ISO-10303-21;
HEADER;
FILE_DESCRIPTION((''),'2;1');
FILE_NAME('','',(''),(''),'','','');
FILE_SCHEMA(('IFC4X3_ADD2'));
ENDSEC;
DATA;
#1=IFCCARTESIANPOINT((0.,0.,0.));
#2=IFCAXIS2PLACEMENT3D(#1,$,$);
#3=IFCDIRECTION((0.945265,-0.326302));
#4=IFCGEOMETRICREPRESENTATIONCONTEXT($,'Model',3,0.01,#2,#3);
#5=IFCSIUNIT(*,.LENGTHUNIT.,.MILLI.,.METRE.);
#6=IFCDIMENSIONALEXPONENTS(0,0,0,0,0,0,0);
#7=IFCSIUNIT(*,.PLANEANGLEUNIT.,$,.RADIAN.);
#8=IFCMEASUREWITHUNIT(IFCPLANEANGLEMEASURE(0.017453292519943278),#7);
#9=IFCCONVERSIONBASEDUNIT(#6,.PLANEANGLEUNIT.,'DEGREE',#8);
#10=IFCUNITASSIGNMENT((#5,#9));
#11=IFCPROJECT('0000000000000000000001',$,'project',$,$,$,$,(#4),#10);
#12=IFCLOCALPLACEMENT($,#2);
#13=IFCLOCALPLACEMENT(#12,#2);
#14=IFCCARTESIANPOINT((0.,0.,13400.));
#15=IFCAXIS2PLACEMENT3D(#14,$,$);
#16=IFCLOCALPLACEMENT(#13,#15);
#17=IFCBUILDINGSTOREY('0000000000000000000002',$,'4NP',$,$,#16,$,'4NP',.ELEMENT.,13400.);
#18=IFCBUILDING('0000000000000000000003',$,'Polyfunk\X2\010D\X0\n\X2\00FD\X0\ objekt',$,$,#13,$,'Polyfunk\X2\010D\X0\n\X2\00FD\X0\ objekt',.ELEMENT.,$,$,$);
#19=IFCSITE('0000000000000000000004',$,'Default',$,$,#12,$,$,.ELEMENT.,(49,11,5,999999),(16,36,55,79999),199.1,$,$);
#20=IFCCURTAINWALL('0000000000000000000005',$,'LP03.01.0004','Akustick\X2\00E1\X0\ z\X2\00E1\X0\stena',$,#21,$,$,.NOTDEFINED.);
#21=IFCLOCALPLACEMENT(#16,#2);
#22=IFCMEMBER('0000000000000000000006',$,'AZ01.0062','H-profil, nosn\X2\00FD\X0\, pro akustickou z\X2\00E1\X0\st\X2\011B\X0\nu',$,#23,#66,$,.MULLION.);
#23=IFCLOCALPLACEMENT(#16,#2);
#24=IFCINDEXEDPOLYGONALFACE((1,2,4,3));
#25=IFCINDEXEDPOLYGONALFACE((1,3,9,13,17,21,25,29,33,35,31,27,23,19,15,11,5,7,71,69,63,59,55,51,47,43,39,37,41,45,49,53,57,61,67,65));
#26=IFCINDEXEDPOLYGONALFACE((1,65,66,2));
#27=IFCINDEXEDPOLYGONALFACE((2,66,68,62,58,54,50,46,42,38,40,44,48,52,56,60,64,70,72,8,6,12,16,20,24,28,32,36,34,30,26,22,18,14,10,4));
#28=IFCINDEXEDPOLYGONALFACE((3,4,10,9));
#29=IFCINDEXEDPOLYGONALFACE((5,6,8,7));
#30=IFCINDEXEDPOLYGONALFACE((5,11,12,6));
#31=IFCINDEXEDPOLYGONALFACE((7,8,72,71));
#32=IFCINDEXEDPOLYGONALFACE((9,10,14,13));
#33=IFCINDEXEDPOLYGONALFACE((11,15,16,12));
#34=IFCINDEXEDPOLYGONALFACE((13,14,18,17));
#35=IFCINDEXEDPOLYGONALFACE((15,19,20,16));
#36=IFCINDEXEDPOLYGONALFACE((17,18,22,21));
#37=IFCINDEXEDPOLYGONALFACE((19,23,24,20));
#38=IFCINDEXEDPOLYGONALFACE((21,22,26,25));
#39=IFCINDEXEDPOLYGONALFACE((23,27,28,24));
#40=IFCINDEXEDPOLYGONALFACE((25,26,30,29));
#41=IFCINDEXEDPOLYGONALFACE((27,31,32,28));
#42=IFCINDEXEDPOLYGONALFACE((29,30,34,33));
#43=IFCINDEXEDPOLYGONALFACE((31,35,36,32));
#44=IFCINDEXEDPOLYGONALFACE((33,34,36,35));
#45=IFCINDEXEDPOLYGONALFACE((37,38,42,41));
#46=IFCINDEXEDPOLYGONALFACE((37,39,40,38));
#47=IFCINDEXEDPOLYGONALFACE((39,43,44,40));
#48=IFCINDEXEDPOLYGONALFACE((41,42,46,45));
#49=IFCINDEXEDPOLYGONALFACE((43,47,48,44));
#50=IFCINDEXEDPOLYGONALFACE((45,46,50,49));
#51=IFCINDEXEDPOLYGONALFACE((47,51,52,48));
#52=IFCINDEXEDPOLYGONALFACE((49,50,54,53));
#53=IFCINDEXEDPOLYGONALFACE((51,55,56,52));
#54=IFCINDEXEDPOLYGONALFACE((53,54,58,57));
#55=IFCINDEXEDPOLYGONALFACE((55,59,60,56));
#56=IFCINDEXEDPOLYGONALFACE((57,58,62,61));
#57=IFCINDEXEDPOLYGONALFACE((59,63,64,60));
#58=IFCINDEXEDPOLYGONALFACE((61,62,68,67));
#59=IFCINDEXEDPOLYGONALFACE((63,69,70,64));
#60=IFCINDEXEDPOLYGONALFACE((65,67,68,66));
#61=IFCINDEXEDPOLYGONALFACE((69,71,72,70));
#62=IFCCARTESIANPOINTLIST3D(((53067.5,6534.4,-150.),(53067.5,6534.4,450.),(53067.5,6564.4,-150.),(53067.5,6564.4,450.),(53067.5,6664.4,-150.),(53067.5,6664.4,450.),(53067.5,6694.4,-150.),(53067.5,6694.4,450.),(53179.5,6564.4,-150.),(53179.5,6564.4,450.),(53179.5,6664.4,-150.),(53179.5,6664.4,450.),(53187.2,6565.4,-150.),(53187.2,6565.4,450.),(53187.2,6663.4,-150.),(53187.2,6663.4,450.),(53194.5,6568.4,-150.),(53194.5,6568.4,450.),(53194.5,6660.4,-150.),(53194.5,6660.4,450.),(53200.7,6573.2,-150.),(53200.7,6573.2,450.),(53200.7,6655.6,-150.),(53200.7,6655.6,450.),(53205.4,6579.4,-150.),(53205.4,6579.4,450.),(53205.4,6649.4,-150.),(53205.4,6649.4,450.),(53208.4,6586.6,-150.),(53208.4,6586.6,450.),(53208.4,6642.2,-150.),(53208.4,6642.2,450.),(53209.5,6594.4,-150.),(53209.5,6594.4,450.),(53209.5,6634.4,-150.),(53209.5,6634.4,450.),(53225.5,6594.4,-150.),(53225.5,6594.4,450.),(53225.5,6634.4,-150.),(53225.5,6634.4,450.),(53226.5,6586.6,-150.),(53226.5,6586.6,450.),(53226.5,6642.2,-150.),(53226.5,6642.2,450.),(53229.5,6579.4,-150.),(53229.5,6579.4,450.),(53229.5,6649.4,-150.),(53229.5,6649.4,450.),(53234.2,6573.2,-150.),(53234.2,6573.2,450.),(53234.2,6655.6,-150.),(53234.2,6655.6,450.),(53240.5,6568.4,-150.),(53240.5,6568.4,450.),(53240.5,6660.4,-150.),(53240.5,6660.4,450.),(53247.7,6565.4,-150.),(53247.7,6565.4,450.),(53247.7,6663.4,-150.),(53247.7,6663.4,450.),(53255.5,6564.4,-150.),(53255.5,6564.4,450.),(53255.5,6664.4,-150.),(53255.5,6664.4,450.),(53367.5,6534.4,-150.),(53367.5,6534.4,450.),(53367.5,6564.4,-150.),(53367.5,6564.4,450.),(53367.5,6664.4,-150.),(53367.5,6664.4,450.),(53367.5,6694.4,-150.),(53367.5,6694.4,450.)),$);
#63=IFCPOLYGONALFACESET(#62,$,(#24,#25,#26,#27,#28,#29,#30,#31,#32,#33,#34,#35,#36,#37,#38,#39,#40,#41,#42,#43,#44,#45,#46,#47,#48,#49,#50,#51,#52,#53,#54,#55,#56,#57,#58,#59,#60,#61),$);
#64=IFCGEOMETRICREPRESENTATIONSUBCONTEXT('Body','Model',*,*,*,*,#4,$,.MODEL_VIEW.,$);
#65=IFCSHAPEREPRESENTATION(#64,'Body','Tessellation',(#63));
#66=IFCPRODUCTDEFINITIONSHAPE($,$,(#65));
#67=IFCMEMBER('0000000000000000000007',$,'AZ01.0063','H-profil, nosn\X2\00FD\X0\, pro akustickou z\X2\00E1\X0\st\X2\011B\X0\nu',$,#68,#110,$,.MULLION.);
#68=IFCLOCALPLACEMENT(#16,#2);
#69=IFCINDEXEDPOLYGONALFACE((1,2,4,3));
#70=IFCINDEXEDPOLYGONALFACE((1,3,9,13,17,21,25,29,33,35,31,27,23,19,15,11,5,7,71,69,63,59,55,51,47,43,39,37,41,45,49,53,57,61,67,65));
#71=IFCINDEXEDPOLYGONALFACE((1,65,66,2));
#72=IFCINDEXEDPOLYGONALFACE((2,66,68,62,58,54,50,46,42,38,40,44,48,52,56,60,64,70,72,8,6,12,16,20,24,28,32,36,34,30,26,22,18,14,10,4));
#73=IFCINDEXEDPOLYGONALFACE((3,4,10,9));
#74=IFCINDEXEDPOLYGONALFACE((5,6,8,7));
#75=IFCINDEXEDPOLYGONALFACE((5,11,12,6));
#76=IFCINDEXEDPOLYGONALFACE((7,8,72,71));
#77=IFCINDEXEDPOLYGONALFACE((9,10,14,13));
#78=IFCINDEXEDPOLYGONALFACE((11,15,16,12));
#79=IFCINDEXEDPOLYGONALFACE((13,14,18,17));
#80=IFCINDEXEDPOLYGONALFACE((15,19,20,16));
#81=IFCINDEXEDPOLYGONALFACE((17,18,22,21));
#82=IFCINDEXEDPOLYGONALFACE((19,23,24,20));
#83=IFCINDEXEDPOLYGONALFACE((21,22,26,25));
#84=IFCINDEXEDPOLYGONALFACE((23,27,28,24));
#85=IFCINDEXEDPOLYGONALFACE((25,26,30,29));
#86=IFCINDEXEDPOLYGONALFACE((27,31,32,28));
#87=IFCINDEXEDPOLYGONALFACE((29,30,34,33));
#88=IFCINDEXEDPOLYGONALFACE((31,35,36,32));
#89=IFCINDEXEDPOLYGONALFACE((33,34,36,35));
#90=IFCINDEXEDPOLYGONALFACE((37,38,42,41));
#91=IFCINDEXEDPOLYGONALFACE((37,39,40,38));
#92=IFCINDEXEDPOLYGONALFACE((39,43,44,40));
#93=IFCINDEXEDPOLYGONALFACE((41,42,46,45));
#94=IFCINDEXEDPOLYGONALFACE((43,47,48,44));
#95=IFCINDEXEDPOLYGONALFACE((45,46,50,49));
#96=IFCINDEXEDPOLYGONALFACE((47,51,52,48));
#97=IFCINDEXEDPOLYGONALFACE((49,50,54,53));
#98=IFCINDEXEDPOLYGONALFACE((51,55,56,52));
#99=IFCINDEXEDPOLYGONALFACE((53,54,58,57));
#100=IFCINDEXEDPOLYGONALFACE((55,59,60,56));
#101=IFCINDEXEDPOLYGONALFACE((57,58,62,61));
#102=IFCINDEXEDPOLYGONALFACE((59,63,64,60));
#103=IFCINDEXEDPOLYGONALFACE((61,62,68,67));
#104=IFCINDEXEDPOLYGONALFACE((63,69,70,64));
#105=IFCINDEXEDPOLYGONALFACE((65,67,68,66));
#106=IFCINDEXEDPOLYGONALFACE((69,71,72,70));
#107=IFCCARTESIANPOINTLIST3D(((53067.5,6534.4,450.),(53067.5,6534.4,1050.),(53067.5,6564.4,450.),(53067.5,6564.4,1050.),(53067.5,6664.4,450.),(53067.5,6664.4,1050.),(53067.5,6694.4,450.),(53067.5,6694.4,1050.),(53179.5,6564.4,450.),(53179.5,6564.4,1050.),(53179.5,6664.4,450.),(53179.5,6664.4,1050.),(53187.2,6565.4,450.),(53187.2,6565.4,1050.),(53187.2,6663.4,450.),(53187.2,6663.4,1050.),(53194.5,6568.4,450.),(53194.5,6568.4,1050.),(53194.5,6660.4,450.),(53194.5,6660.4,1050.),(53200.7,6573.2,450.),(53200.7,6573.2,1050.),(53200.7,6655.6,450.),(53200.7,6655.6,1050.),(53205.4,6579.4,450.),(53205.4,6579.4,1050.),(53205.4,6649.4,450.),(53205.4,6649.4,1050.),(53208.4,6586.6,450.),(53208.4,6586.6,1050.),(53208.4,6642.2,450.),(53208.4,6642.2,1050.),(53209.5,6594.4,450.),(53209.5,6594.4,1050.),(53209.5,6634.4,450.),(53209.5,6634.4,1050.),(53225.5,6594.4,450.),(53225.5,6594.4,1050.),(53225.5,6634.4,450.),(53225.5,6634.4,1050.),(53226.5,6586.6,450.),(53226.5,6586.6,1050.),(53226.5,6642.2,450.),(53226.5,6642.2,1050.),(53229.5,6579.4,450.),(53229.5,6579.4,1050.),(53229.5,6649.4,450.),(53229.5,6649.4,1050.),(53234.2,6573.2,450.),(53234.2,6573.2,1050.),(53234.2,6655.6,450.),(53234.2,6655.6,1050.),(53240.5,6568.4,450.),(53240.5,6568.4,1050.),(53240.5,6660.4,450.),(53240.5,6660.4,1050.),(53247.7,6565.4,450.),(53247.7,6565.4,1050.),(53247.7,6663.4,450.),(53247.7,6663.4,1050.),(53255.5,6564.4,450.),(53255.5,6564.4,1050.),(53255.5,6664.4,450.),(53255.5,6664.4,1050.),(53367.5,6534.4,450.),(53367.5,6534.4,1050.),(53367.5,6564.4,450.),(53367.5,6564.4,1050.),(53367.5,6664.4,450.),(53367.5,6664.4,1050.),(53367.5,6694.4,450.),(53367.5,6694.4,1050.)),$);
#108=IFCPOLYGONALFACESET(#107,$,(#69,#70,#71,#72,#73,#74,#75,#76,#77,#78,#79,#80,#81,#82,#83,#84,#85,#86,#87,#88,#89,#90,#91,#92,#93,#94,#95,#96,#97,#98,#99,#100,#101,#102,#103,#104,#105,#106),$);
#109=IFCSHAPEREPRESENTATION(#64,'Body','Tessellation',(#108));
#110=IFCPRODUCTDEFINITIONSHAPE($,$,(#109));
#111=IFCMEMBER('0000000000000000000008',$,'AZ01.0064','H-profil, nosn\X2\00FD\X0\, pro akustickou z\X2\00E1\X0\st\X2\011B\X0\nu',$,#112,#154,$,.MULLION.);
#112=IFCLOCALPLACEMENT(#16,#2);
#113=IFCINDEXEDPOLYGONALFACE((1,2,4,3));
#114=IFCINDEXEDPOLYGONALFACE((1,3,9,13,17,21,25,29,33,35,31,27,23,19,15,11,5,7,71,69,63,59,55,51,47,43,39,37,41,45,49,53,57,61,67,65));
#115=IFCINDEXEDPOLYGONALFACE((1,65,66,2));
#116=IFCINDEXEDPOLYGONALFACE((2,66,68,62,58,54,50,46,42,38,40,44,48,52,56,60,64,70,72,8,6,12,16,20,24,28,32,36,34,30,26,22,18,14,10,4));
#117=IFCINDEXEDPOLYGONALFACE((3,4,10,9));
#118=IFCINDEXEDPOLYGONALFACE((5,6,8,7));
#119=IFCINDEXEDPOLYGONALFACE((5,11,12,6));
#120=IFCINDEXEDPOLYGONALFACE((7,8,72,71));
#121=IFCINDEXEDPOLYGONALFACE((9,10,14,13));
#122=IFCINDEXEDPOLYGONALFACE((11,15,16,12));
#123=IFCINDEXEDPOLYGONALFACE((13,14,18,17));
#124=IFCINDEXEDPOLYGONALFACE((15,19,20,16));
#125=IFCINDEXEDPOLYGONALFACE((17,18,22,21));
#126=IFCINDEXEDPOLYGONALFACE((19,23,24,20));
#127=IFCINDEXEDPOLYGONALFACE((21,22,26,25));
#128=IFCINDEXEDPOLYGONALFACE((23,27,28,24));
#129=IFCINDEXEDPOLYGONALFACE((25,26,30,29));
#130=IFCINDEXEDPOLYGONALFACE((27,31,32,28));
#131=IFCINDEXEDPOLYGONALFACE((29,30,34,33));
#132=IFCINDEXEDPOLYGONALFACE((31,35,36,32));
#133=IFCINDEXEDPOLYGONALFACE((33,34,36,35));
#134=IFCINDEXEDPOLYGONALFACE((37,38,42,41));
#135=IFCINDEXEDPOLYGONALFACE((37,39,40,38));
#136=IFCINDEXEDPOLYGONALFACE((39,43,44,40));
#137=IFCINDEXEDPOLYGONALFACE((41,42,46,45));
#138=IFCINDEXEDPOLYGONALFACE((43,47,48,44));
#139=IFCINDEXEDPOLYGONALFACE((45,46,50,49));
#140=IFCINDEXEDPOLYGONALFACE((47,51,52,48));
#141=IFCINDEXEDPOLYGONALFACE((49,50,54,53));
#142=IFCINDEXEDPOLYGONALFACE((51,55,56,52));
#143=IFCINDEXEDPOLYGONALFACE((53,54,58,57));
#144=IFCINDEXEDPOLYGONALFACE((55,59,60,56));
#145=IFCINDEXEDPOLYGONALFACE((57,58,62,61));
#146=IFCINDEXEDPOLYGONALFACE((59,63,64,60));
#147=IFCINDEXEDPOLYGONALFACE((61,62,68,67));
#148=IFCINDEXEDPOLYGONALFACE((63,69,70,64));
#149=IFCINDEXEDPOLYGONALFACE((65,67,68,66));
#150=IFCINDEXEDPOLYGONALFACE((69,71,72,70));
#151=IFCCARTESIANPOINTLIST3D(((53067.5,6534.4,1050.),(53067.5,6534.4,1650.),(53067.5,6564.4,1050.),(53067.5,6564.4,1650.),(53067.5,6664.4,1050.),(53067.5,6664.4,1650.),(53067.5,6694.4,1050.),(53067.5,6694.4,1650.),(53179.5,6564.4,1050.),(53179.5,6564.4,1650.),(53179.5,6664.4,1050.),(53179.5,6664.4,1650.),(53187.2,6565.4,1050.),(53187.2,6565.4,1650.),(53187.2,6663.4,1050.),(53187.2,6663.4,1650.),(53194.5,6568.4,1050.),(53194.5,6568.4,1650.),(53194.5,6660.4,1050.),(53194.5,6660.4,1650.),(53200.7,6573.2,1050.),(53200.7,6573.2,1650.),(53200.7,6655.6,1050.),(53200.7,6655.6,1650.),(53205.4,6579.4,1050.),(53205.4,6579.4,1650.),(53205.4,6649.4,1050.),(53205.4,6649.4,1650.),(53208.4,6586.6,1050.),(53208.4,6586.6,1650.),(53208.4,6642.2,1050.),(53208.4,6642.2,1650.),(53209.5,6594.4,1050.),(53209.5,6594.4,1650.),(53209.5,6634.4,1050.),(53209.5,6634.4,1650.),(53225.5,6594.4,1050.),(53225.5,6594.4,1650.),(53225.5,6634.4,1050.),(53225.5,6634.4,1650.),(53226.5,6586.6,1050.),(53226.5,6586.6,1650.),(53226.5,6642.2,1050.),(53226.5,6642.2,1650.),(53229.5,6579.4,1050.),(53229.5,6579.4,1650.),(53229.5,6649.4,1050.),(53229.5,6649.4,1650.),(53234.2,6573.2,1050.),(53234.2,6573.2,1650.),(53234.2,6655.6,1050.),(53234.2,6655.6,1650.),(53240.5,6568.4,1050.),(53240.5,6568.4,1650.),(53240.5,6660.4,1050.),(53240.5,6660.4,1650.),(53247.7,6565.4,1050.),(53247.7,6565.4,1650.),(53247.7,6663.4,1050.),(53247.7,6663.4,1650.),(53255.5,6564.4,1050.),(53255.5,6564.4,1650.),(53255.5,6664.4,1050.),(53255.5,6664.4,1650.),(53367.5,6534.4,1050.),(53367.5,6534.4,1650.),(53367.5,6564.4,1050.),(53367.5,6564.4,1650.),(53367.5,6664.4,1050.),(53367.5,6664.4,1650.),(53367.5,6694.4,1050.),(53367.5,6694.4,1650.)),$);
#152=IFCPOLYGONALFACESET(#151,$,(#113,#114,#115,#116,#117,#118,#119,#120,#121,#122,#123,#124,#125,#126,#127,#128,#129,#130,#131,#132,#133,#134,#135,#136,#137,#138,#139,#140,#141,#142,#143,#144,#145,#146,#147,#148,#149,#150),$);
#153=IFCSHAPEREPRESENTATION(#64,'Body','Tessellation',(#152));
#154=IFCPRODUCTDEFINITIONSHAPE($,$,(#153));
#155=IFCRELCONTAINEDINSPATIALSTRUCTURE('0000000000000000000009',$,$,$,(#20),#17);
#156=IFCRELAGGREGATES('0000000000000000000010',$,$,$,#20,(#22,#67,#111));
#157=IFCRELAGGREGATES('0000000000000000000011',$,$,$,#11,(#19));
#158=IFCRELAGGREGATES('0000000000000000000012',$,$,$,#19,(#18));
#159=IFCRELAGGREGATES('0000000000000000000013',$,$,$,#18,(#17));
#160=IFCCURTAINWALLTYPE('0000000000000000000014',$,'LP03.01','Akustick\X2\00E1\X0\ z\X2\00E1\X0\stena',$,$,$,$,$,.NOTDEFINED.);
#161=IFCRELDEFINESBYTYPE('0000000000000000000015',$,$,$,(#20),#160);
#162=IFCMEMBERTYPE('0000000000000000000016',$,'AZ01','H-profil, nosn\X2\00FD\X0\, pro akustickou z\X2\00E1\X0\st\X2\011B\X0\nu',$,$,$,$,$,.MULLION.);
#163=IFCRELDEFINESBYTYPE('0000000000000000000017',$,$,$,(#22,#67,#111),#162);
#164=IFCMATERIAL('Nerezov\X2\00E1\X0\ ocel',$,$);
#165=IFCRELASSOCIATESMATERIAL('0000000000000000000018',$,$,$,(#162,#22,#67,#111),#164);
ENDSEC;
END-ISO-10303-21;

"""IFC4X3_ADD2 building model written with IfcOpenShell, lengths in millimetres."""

from ifc_helpers import new_model, entity, si_unit, converted_unit, direction, frame, frame_2d, origin, place, context, subcontext, project, spatial, polyline, circle_curve, parameter, trimmed, segment, composite_curve, outline, extrude, source, transform, mapped, material, material_profile, profile_set, profile_usage, type_object, element, aggregate, save


model = new_model("IFC4X3_ADD2")

# Units and contexts
model_context = context("Model", 3, precision=0.01, world=origin(), true_north=direction((0.945265, -0.326302)))
body_context = subcontext(model_context, "Body", "Model", "MODEL_VIEW")
ifc_project = project(units=[si_unit("LENGTHUNIT", "METRE", prefix="MILLI"), converted_unit("PLANEANGLEUNIT", "DEGREE", entity("IfcPlaneAngleMeasure", 0.017453292519943278), si_unit("PLANEANGLEUNIT", "RADIAN"), dimensions=[0, 0, 0, 0, 0, 0, 0])], contexts=[model_context])

# Site, building, storey
site_placement = place(None, origin())
site = spatial("IfcSite", under=ifc_project, at=site_placement, Name="Default", CompositionType="ELEMENT", RefLatitude=(49, 11, 5, 999999), RefLongitude=(16, 36, 55, 79999), RefElevation=199.1)
building_placement = place(site_placement, origin())
building = spatial("IfcBuilding", under=site, at=building_placement, Name="Polyfunkčný objekt", LongName="Polyfunkčný objekt", CompositionType="ELEMENT")
storey_placement = place(building_placement, frame((0.0, 0.0, 13400.0)))
storey = spatial("IfcBuildingStorey", under=building, at=storey_placement, Name="4NP", LongName="4NP", CompositionType="ELEMENT", Elevation=13400.0)

# Curtain wall, members
curtain_wall_type = type_object("IfcCurtainWallType", Name="LP03.01", Description="Akustická zástena", PredefinedType="NOTDEFINED")
curtain_wall_placement = place(storey_placement, frame((0.0, 0.0, -13400.0)))
curtain_wall = element("IfcCurtainWall", 1, at=curtain_wall_placement, inside=storey, type_object=curtain_wall_type, Name="LP03.01.0004", Description="Akustická zástena", PredefinedType="NOTDEFINED")
ifc_material_1 = material(Name="Nerezová ocel")
ifc_material_profile = material_profile(ifc_material_1, outline(composite_curve([segment(polyline([(50.0, -150.0), (80.0, -150.0)]), True, "CONTINUOUS"), segment(polyline([(80.0, -150.0), (80.0, 150.0)]), True, "CONTINUOUS"), segment(polyline([(80.0, 150.0), (50.0, 150.0)]), True, "CONTINUOUS"), segment(polyline([(50.0, 150.0), (50.0, 38.0)]), True, "CONTINUOUS"), segment(trimmed(circle_curve(frame_2d((20.0, 38.0), x_axis=(0.0, 1.0)), 30.0), [parameter(180.0)], [parameter(270.0)], True, "PARAMETER"), False, "CONTINUOUS"), segment(polyline([(20.0, 8.0), (-20.0, 8.0)]), True, "CONTINUOUS"), segment(trimmed(circle_curve(frame_2d((-20.0, 38.0), x_axis=(0.0, 1.0)), 30.0), [parameter(90.0)], [parameter(180.0)], True, "PARAMETER"), False, "CONTINUOUS"), segment(polyline([(-50.0, 38.0), (-50.0, 150.0)]), True, "CONTINUOUS"), segment(polyline([(-50.0, 150.0), (-80.0, 150.0)]), True, "CONTINUOUS"), segment(polyline([(-80.0, 150.0), (-80.0, -150.0)]), True, "CONTINUOUS"), segment(polyline([(-80.0, -150.0), (-50.0, -150.0)]), True, "CONTINUOUS"), segment(polyline([(-50.0, -150.0), (-50.0, -38.0)]), True, "CONTINUOUS"), segment(trimmed(circle_curve(frame_2d((-20.0, -38.0), x_axis=(0.0, 1.0)), 30.0), [parameter(0.0)], [parameter(90.0)], True, "PARAMETER"), False, "CONTINUOUS"), segment(polyline([(-20.0, -8.0), (20.0, -8.0)]), True, "CONTINUOUS"), segment(trimmed(circle_curve(frame_2d((20.0, -38.0), x_axis=(0.0, 1.0)), 30.0), [parameter(270.0)], [parameter(0.0)], True, "PARAMETER"), False, "CONTINUOUS"), segment(polyline([(50.0, -38.0), (50.0, -150.0)]), True, "CONTINUOUS")], self_intersect=False)), Name="Profil zástena")
ifc_profile_set = profile_set([ifc_material_profile], Name="Profil zástena")
ifc_profile_usage = profile_usage(ifc_profile_set)
member_type = type_object("IfcMemberType", Name="AZ01", Description="H-profil, nosný, pro akustickou zástěnu", PredefinedType="MULLION", material=ifc_profile_set)
shared_shape_1 = source(origin(), body_context, "Body", "SweptSolid", [
    extrude(outline(composite_curve([segment(polyline([(50.0, -150.0), (80.0, -150.0)]), True, "CONTINUOUS"), segment(polyline([(80.0, -150.0), (80.0, 150.0)]), True, "CONTINUOUS"), segment(polyline([(80.0, 150.0), (50.0, 150.0)]), True, "CONTINUOUS"), segment(polyline([(50.0, 150.0), (50.0, 38.0)]), True, "CONTINUOUS"), segment(trimmed(circle_curve(frame_2d((20.0, 38.0), x_axis=(0.0, 1.0)), 30.0), [parameter(180.0)], [parameter(270.0)], True, "PARAMETER"), False, "CONTINUOUS"), segment(polyline([(20.0, 8.0), (-20.0, 8.0)]), True, "CONTINUOUS"), segment(trimmed(circle_curve(frame_2d((-20.0, 38.0), x_axis=(0.0, 1.0)), 30.0), [parameter(90.0)], [parameter(180.0)], True, "PARAMETER"), False, "CONTINUOUS"), segment(polyline([(-50.0, 38.0), (-50.0, 150.0)]), True, "CONTINUOUS"), segment(polyline([(-50.0, 150.0), (-80.0, 150.0)]), True, "CONTINUOUS"), segment(polyline([(-80.0, 150.0), (-80.0, -150.0)]), True, "CONTINUOUS"), segment(polyline([(-80.0, -150.0), (-50.0, -150.0)]), True, "CONTINUOUS"), segment(polyline([(-50.0, -150.0), (-50.0, -38.0)]), True, "CONTINUOUS"), segment(trimmed(circle_curve(frame_2d((-20.0, -38.0), x_axis=(0.0, 1.0)), 30.0), [parameter(0.0)], [parameter(90.0)], True, "PARAMETER"), False, "CONTINUOUS"), segment(polyline([(-20.0, -8.0), (20.0, -8.0)]), True, "CONTINUOUS"), segment(trimmed(circle_curve(frame_2d((20.0, -38.0), x_axis=(0.0, 1.0)), 30.0), [parameter(270.0)], [parameter(0.0)], True, "PARAMETER"), False, "CONTINUOUS"), segment(polyline([(50.0, -38.0), (50.0, -150.0)]), True, "CONTINUOUS")], self_intersect=False)), frame((0.0, 0.0, -600.0), z_axis=(0.0, 0.0, 1.0), x_axis=(0.0, -1.0, 0.0)), (0.0, 0.0, 1.0), 600.0),
])
member_1_placement = place(curtain_wall_placement, frame((53217.5, 6614.4, 13250.0), z_axis=(0.0, 0.0, -1.0), x_axis=(1.0, 0.0, 0.0)))
member_1 = element("IfcMember", 2, at=member_1_placement, type_object=member_type, material=ifc_profile_usage, Name="AZ01.0062", Description="H-profil, nosný, pro akustickou zástěnu", PredefinedType="MULLION", context=body_context, shape_type="MappedRepresentation", body=[
    mapped(shared_shape_1, transform((0.0, 0.0, 0.0), scale=1.0)),
])
shared_shape_2 = source(origin(), body_context, "Body", "SweptSolid", [
    extrude(outline(composite_curve([segment(polyline([(50.0, -150.0), (80.0, -150.0)]), True, "CONTINUOUS"), segment(polyline([(80.0, -150.0), (80.0, 150.0)]), True, "CONTINUOUS"), segment(polyline([(80.0, 150.0), (50.0, 150.0)]), True, "CONTINUOUS"), segment(polyline([(50.0, 150.0), (50.0, 38.0)]), True, "CONTINUOUS"), segment(trimmed(circle_curve(frame_2d((20.0, 38.0), x_axis=(0.0, 1.0)), 30.0), [parameter(180.0)], [parameter(270.0)], True, "PARAMETER"), False, "CONTINUOUS"), segment(polyline([(20.0, 8.0), (-20.0, 8.0)]), True, "CONTINUOUS"), segment(trimmed(circle_curve(frame_2d((-20.0, 38.0), x_axis=(0.0, 1.0)), 30.0), [parameter(90.0)], [parameter(180.0)], True, "PARAMETER"), False, "CONTINUOUS"), segment(polyline([(-50.0, 38.0), (-50.0, 150.0)]), True, "CONTINUOUS"), segment(polyline([(-50.0, 150.0), (-80.0, 150.0)]), True, "CONTINUOUS"), segment(polyline([(-80.0, 150.0), (-80.0, -150.0)]), True, "CONTINUOUS"), segment(polyline([(-80.0, -150.0), (-50.0, -150.0)]), True, "CONTINUOUS"), segment(polyline([(-50.0, -150.0), (-50.0, -38.0)]), True, "CONTINUOUS"), segment(trimmed(circle_curve(frame_2d((-20.0, -38.0), x_axis=(0.0, 1.0)), 30.0), [parameter(0.0)], [parameter(90.0)], True, "PARAMETER"), False, "CONTINUOUS"), segment(polyline([(-20.0, -8.0), (20.0, -8.0)]), True, "CONTINUOUS"), segment(trimmed(circle_curve(frame_2d((20.0, -38.0), x_axis=(0.0, 1.0)), 30.0), [parameter(270.0)], [parameter(0.0)], True, "PARAMETER"), False, "CONTINUOUS"), segment(polyline([(50.0, -38.0), (50.0, -150.0)]), True, "CONTINUOUS")], self_intersect=False)), frame((0.0, 0.0, -600.0), z_axis=(0.0, 0.0, 1.0), x_axis=(0.0, -1.0, 0.0)), (0.0, 0.0, 1.0), 600.0),
])
member_2_placement = place(curtain_wall_placement, frame((53217.5, 6614.4, 13850.0), z_axis=(0.0, 0.0, -1.0), x_axis=(1.0, 0.0, 0.0)))
member_2 = element("IfcMember", 3, at=member_2_placement, type_object=member_type, material=ifc_profile_usage, Name="AZ01.0063", Description="H-profil, nosný, pro akustickou zástěnu", PredefinedType="MULLION", context=body_context, shape_type="MappedRepresentation", body=[
    mapped(shared_shape_2, transform((0.0, 0.0, 0.0), scale=1.0)),
])
member_3_placement = place(curtain_wall_placement, frame((53217.5, 6614.4, 14450.0), z_axis=(0.0, 0.0, -1.0), x_axis=(1.0, 0.0, 0.0)))
member_3 = element("IfcMember", 4, at=member_3_placement, type_object=member_type, material=ifc_profile_usage, Name="AZ01.0064", Description="H-profil, nosný, pro akustickou zástěnu", PredefinedType="MULLION", context=body_context, shape_type="MappedRepresentation", body=[
    mapped(shared_shape_2, transform((0.0, 0.0, 0.0), scale=1.0)),
])
aggregate(curtain_wall, [member_1, member_2, member_3])

save(model, "model.ifc")
